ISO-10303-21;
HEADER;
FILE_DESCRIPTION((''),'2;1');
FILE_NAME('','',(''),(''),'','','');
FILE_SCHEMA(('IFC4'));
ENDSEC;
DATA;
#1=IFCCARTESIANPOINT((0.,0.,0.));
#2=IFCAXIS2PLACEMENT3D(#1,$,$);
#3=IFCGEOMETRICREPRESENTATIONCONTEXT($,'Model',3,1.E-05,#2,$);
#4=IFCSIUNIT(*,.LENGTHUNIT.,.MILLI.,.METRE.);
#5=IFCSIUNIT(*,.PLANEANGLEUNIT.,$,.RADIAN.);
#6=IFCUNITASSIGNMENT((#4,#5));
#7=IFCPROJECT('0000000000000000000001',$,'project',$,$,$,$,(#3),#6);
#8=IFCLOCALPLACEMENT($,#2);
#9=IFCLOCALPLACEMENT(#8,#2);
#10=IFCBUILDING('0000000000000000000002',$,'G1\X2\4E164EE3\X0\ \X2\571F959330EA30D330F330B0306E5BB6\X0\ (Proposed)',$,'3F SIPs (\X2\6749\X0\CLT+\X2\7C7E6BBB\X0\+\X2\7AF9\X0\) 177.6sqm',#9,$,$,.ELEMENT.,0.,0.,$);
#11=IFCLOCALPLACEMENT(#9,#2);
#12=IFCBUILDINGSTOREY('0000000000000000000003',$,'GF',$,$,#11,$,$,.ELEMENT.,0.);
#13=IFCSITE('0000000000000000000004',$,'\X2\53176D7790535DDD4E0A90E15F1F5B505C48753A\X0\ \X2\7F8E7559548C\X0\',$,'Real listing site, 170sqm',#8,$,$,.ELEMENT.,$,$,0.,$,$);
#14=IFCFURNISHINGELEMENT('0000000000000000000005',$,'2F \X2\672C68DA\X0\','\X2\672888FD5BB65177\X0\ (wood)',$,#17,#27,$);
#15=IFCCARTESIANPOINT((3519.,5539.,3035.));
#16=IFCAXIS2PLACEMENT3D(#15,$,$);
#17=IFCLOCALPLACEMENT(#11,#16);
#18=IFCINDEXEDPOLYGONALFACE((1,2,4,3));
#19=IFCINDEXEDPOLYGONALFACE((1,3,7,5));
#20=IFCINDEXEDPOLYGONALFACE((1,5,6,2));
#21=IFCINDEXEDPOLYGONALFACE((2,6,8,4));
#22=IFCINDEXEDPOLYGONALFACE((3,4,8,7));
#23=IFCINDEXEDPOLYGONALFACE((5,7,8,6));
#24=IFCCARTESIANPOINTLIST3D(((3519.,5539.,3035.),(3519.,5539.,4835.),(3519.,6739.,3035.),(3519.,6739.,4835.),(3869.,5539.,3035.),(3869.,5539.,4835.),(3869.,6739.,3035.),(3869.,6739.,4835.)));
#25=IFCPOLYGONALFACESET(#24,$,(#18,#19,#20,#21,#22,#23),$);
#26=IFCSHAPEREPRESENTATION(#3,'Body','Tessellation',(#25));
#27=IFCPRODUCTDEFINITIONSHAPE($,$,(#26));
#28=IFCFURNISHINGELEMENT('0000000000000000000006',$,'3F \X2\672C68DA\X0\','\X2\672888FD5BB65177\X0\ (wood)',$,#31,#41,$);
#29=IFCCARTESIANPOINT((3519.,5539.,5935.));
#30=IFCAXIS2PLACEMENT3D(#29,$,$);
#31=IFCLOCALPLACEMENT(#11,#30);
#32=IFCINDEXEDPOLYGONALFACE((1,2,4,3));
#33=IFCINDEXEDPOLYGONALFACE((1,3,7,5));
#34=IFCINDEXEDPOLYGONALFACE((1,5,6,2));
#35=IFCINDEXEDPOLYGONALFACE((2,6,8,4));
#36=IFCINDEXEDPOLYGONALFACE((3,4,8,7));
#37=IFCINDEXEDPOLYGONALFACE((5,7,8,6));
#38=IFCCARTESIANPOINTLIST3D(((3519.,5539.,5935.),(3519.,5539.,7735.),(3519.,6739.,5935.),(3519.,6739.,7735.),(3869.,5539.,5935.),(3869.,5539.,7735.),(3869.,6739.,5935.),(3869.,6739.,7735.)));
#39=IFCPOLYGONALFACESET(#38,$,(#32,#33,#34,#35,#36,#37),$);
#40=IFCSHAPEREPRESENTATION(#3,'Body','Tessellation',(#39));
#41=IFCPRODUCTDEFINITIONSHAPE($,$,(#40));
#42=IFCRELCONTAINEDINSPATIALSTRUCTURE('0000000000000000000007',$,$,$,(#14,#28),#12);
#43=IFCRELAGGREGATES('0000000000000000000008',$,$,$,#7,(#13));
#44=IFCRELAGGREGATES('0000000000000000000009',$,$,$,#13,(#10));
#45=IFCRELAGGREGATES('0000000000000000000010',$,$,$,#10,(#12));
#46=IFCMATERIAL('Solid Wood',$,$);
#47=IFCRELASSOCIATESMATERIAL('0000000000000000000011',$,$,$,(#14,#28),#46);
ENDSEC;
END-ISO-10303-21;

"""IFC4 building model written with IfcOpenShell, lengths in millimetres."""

from ifc_helpers import new_model, si_unit, frame, frame_2d, origin, place, context, project, spatial, rectangle, extrude, material, element, save


model = new_model("IFC4")

# Units and contexts
model_context = context("Model", 3, precision=1e-05, world=origin())
ifc_project = project(units=[si_unit("LENGTHUNIT", "METRE", prefix="MILLI"), si_unit("PLANEANGLEUNIT", "RADIAN")], contexts=[model_context])

# Site, building, storey
site_placement = place(None, origin())
site = spatial("IfcSite", under=ifc_project, at=site_placement, Name="北海道川上郡弟子屈町 美留和", ObjectType="Real listing site, 170sqm", CompositionType="ELEMENT", RefElevation=0.0)
building_placement = place(site_placement, origin())
building = spatial("IfcBuilding", under=site, at=building_placement, Name="G1世代 土間リビングの家 (Proposed)", ObjectType="3F SIPs (杉CLT+籾殻+竹) 177.6sqm", CompositionType="ELEMENT", ElevationOfRefHeight=0.0, ElevationOfTerrain=0.0)
storey_placement = place(building_placement, origin())
storey = spatial("IfcBuildingStorey", under=building, at=storey_placement, Name="GF", CompositionType="ELEMENT", Elevation=0.0)

# Shared definitions
ifc_material_1 = material(Name="Solid Wood")

# Furnishing elements
furnishing_1_placement = place(storey_placement, frame((3519.0, 5539.0, 3035.0)))
element("IfcFurnishingElement", 1, at=furnishing_1_placement, inside=storey, material=ifc_material_1, Name="2F 本棚", Description="木製家具 (wood)", context=model_context, shape_type="SweptSolid", body=[
    extrude(rectangle(XDim=350.0, YDim=1200.0, at=frame_2d((175.0, 600.0))), frame((3519.0, 5539.0, 3035.0)), (0.0, 0.0, 1.0), 1800.0),
])
furnishing_2_placement = place(storey_placement, frame((3519.0, 5539.0, 5935.0)))
element("IfcFurnishingElement", 2, at=furnishing_2_placement, inside=storey, material=ifc_material_1, Name="3F 本棚", Description="木製家具 (wood)", context=model_context, shape_type="SweptSolid", body=[
    extrude(rectangle(XDim=350.0, YDim=1200.0, at=frame_2d((175.0, 600.0))), frame((3519.0, 5539.0, 5935.0)), (0.0, 0.0, 1.0), 1800.0),
])

save(model, "model.ifc")
